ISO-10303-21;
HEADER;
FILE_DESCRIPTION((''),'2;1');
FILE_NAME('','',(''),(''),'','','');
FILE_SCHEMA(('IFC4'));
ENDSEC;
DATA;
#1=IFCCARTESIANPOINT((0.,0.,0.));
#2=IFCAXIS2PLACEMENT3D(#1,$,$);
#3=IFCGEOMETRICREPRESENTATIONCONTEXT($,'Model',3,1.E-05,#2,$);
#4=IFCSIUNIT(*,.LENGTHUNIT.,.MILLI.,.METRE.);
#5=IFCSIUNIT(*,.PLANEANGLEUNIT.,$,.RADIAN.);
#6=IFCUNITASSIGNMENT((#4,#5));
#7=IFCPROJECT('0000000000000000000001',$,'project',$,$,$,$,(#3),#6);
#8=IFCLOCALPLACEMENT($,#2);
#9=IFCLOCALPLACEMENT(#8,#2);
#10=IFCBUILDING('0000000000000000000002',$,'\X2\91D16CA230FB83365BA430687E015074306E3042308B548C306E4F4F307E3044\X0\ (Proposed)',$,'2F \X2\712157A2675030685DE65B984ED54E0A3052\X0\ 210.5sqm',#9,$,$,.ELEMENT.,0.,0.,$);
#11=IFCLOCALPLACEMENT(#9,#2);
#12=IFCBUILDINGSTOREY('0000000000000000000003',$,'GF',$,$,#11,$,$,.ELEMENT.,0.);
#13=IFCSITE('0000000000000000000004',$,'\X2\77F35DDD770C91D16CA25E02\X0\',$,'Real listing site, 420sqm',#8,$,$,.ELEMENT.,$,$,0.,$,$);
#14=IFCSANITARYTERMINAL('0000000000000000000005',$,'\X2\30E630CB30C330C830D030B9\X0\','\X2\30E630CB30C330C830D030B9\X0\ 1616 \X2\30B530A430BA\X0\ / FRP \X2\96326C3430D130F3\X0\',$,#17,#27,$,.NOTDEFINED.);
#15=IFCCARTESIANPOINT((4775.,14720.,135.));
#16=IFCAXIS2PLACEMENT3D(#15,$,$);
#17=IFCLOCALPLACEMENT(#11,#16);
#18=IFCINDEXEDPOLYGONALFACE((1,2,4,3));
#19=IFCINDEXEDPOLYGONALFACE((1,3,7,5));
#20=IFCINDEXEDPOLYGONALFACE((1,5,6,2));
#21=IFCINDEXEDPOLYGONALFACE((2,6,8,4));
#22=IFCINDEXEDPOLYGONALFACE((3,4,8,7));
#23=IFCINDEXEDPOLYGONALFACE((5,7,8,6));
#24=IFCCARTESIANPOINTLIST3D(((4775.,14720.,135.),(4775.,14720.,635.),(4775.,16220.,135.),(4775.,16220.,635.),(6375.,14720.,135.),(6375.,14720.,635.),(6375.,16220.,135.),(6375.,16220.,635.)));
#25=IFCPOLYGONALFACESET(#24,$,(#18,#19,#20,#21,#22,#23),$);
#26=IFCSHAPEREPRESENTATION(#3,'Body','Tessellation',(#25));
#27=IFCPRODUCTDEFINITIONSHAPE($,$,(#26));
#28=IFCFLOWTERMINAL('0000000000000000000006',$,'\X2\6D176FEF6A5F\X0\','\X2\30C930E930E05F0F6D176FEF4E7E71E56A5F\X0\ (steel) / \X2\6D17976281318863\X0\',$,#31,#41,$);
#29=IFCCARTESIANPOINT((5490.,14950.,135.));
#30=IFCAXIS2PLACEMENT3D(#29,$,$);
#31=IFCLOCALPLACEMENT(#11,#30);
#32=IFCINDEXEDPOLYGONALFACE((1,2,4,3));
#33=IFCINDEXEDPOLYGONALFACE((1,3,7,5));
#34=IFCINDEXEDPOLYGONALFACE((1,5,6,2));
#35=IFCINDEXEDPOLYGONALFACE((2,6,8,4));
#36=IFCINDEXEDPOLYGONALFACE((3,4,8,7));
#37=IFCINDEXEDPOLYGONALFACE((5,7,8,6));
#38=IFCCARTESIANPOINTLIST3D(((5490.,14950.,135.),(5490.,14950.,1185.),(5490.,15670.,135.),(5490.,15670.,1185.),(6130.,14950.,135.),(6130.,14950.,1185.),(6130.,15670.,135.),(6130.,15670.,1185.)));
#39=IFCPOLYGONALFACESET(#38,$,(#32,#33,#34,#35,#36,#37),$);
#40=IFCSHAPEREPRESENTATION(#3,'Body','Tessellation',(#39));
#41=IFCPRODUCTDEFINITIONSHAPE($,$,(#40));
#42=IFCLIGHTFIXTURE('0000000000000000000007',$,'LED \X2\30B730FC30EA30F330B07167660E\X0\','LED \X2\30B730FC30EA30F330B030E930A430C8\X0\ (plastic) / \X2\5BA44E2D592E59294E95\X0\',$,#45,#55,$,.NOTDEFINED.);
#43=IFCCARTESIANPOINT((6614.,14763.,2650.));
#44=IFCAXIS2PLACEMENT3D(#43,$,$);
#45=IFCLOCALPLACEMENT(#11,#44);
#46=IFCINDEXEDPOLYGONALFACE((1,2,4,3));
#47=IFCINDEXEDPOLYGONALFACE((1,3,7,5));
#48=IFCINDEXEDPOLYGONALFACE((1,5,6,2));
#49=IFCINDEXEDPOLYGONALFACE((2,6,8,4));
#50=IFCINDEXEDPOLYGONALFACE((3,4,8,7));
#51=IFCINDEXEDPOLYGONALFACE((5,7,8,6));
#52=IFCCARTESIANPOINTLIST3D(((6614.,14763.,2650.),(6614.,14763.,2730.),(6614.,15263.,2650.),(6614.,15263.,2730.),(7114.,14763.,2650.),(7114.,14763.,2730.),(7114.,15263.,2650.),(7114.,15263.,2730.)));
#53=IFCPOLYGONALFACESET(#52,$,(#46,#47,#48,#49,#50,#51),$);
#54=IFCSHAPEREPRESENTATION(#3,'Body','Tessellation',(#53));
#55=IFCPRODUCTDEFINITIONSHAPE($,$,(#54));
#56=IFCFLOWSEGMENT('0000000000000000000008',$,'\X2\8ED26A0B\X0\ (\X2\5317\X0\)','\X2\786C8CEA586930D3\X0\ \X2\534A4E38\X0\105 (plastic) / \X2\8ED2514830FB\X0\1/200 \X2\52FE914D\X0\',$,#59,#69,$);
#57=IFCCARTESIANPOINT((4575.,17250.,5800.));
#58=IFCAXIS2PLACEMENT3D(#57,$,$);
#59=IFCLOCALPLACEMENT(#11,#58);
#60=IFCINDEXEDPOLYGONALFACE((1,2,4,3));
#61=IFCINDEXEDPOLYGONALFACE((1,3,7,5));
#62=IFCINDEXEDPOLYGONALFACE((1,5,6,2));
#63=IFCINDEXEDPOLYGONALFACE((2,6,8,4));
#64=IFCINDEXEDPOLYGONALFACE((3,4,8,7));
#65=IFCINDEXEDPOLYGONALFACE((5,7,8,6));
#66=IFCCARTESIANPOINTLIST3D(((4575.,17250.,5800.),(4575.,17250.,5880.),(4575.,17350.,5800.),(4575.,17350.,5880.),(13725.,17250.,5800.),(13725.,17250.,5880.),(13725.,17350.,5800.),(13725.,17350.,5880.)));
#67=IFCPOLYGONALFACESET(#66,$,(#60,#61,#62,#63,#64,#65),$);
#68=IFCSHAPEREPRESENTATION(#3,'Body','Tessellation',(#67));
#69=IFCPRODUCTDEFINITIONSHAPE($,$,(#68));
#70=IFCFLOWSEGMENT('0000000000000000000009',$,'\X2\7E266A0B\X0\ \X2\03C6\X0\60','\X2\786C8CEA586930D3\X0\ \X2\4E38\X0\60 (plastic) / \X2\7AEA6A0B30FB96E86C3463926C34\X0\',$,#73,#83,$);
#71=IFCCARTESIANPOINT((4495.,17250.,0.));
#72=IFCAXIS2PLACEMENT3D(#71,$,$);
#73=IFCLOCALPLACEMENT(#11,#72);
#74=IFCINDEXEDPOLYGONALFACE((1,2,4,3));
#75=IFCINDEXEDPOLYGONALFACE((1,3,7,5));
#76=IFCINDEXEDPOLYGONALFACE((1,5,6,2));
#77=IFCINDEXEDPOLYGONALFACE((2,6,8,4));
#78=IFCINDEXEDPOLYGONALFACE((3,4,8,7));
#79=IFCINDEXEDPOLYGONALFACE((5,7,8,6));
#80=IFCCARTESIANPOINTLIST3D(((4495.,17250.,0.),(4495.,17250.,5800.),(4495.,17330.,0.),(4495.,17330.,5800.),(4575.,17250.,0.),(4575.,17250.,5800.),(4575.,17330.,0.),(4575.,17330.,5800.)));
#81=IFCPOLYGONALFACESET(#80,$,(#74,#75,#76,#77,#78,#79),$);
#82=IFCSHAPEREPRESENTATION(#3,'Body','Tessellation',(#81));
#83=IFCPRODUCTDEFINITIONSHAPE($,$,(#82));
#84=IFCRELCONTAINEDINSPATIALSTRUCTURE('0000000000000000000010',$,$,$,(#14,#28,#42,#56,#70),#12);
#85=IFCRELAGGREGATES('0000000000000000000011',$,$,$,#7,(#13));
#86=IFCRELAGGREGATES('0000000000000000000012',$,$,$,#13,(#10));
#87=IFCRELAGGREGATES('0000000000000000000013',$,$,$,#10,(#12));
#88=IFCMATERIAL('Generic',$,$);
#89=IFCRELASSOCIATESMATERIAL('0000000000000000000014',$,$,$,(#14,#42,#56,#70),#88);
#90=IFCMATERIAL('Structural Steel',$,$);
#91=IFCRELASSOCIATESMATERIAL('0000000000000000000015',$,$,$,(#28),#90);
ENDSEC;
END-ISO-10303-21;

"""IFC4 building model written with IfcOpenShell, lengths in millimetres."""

from ifc_helpers import new_model, si_unit, frame, frame_2d, origin, place, context, project, spatial, rectangle, extrude, material, element, save


model = new_model("IFC4")

# Units and contexts
model_context = context("Model", 3, precision=1e-05, world=origin())
ifc_project = project(units=[si_unit("LENGTHUNIT", "METRE", prefix="MILLI"), si_unit("PLANEANGLEUNIT", "RADIAN")], contexts=[model_context])

# Site, building, storey
site_placement = place(None, origin())
site = spatial("IfcSite", under=ifc_project, at=site_placement, Name="石川県金沢市", ObjectType="Real listing site, 420sqm", CompositionType="ELEMENT", RefElevation=0.0)
building_placement = place(site_placement, origin())
building = spatial("IfcBuilding", under=site, at=building_placement, Name="金沢・茶室と縁側のある和の住まい (Proposed)", ObjectType="2F 無垢材と左官仕上げ 210.5sqm", CompositionType="ELEMENT", ElevationOfRefHeight=0.0, ElevationOfTerrain=0.0)
storey_placement = place(building_placement, origin())
storey = spatial("IfcBuildingStorey", under=building, at=storey_placement, Name="GF", CompositionType="ELEMENT", Elevation=0.0)

# Sanitary terminal
ifc_material_1 = material(Name="Generic")
sanitary_terminal_placement = place(storey_placement, frame((4775.0, 14720.0, 135.0)))
element("IfcSanitaryTerminal", 1, at=sanitary_terminal_placement, inside=storey, material=ifc_material_1, Name="ユニットバス", Description="ユニットバス 1616 サイズ / FRP 防水パン", PredefinedType="NOTDEFINED", context=model_context, shape_type="SweptSolid", body=[
    extrude(rectangle(XDim=1600.0, YDim=1500.0, at=frame_2d((800.0, 750.0))), frame((4775.0, 14720.0, 135.0)), (0.0, 0.0, 1.0), 500.0),
])

# Flow terminal
ifc_material_2 = material(Name="Structural Steel")
flow_terminal_placement = place(storey_placement, frame((5490.0, 14950.0, 135.0)))
element("IfcFlowTerminal", 2, at=flow_terminal_placement, inside=storey, material=ifc_material_2, Name="洗濯機", Description="ドラム式洗濯乾燥機 (steel) / 洗面脱衣", context=model_context, shape_type="SweptSolid", body=[
    extrude(rectangle(XDim=640.0, YDim=720.0, at=frame_2d((320.0, 360.0))), frame((5490.0, 14950.0, 135.0)), (0.0, 0.0, 1.0), 1050.0),
])

# Light fixture
light_fixture_placement = place(storey_placement, frame((6614.0, 14763.0, 2650.0)))
element("IfcLightFixture", 3, at=light_fixture_placement, inside=storey, material=ifc_material_1, Name="LED シーリング照明", Description="LED シーリングライト (plastic) / 室中央天井", PredefinedType="NOTDEFINED", context=model_context, shape_type="SweptSolid", body=[
    extrude(rectangle(XDim=500.0, YDim=500.0, at=frame_2d((250.0, 250.0))), frame((6614.0, 14763.0, 2650.0)), (0.0, 0.0, 1.0), 80.0),
])

# Flow segments
flow_segment_1_placement = place(storey_placement, frame((4575.0, 17250.0, 5800.0)))
element("IfcFlowSegment", 4, at=flow_segment_1_placement, inside=storey, material=ifc_material_1, Name="軒樋 (北)", Description="硬質塩ビ 半丸105 (plastic) / 軒先・1/200 勾配", context=model_context, shape_type="SweptSolid", body=[
    extrude(rectangle(XDim=9150.0, YDim=100.0, at=frame_2d((4575.0, 50.0))), frame((4575.0, 17250.0, 5800.0)), (0.0, 0.0, 1.0), 80.0),
])
flow_segment_2_placement = place(storey_placement, frame((4495.0, 17250.0, 0.0)))
element("IfcFlowSegment", 5, at=flow_segment_2_placement, inside=storey, material=ifc_material_1, Name="縦樋 φ60", Description="硬質塩ビ 丸60 (plastic) / 竪樋・雨水排水", context=model_context, shape_type="SweptSolid", body=[
    extrude(rectangle(XDim=80.0, YDim=80.0, at=frame_2d((40.0, 40.0))), frame((4495.0, 17250.0, 0.0)), (0.0, 0.0, 1.0), 5800.0),
])

save(model, "model.ifc")
